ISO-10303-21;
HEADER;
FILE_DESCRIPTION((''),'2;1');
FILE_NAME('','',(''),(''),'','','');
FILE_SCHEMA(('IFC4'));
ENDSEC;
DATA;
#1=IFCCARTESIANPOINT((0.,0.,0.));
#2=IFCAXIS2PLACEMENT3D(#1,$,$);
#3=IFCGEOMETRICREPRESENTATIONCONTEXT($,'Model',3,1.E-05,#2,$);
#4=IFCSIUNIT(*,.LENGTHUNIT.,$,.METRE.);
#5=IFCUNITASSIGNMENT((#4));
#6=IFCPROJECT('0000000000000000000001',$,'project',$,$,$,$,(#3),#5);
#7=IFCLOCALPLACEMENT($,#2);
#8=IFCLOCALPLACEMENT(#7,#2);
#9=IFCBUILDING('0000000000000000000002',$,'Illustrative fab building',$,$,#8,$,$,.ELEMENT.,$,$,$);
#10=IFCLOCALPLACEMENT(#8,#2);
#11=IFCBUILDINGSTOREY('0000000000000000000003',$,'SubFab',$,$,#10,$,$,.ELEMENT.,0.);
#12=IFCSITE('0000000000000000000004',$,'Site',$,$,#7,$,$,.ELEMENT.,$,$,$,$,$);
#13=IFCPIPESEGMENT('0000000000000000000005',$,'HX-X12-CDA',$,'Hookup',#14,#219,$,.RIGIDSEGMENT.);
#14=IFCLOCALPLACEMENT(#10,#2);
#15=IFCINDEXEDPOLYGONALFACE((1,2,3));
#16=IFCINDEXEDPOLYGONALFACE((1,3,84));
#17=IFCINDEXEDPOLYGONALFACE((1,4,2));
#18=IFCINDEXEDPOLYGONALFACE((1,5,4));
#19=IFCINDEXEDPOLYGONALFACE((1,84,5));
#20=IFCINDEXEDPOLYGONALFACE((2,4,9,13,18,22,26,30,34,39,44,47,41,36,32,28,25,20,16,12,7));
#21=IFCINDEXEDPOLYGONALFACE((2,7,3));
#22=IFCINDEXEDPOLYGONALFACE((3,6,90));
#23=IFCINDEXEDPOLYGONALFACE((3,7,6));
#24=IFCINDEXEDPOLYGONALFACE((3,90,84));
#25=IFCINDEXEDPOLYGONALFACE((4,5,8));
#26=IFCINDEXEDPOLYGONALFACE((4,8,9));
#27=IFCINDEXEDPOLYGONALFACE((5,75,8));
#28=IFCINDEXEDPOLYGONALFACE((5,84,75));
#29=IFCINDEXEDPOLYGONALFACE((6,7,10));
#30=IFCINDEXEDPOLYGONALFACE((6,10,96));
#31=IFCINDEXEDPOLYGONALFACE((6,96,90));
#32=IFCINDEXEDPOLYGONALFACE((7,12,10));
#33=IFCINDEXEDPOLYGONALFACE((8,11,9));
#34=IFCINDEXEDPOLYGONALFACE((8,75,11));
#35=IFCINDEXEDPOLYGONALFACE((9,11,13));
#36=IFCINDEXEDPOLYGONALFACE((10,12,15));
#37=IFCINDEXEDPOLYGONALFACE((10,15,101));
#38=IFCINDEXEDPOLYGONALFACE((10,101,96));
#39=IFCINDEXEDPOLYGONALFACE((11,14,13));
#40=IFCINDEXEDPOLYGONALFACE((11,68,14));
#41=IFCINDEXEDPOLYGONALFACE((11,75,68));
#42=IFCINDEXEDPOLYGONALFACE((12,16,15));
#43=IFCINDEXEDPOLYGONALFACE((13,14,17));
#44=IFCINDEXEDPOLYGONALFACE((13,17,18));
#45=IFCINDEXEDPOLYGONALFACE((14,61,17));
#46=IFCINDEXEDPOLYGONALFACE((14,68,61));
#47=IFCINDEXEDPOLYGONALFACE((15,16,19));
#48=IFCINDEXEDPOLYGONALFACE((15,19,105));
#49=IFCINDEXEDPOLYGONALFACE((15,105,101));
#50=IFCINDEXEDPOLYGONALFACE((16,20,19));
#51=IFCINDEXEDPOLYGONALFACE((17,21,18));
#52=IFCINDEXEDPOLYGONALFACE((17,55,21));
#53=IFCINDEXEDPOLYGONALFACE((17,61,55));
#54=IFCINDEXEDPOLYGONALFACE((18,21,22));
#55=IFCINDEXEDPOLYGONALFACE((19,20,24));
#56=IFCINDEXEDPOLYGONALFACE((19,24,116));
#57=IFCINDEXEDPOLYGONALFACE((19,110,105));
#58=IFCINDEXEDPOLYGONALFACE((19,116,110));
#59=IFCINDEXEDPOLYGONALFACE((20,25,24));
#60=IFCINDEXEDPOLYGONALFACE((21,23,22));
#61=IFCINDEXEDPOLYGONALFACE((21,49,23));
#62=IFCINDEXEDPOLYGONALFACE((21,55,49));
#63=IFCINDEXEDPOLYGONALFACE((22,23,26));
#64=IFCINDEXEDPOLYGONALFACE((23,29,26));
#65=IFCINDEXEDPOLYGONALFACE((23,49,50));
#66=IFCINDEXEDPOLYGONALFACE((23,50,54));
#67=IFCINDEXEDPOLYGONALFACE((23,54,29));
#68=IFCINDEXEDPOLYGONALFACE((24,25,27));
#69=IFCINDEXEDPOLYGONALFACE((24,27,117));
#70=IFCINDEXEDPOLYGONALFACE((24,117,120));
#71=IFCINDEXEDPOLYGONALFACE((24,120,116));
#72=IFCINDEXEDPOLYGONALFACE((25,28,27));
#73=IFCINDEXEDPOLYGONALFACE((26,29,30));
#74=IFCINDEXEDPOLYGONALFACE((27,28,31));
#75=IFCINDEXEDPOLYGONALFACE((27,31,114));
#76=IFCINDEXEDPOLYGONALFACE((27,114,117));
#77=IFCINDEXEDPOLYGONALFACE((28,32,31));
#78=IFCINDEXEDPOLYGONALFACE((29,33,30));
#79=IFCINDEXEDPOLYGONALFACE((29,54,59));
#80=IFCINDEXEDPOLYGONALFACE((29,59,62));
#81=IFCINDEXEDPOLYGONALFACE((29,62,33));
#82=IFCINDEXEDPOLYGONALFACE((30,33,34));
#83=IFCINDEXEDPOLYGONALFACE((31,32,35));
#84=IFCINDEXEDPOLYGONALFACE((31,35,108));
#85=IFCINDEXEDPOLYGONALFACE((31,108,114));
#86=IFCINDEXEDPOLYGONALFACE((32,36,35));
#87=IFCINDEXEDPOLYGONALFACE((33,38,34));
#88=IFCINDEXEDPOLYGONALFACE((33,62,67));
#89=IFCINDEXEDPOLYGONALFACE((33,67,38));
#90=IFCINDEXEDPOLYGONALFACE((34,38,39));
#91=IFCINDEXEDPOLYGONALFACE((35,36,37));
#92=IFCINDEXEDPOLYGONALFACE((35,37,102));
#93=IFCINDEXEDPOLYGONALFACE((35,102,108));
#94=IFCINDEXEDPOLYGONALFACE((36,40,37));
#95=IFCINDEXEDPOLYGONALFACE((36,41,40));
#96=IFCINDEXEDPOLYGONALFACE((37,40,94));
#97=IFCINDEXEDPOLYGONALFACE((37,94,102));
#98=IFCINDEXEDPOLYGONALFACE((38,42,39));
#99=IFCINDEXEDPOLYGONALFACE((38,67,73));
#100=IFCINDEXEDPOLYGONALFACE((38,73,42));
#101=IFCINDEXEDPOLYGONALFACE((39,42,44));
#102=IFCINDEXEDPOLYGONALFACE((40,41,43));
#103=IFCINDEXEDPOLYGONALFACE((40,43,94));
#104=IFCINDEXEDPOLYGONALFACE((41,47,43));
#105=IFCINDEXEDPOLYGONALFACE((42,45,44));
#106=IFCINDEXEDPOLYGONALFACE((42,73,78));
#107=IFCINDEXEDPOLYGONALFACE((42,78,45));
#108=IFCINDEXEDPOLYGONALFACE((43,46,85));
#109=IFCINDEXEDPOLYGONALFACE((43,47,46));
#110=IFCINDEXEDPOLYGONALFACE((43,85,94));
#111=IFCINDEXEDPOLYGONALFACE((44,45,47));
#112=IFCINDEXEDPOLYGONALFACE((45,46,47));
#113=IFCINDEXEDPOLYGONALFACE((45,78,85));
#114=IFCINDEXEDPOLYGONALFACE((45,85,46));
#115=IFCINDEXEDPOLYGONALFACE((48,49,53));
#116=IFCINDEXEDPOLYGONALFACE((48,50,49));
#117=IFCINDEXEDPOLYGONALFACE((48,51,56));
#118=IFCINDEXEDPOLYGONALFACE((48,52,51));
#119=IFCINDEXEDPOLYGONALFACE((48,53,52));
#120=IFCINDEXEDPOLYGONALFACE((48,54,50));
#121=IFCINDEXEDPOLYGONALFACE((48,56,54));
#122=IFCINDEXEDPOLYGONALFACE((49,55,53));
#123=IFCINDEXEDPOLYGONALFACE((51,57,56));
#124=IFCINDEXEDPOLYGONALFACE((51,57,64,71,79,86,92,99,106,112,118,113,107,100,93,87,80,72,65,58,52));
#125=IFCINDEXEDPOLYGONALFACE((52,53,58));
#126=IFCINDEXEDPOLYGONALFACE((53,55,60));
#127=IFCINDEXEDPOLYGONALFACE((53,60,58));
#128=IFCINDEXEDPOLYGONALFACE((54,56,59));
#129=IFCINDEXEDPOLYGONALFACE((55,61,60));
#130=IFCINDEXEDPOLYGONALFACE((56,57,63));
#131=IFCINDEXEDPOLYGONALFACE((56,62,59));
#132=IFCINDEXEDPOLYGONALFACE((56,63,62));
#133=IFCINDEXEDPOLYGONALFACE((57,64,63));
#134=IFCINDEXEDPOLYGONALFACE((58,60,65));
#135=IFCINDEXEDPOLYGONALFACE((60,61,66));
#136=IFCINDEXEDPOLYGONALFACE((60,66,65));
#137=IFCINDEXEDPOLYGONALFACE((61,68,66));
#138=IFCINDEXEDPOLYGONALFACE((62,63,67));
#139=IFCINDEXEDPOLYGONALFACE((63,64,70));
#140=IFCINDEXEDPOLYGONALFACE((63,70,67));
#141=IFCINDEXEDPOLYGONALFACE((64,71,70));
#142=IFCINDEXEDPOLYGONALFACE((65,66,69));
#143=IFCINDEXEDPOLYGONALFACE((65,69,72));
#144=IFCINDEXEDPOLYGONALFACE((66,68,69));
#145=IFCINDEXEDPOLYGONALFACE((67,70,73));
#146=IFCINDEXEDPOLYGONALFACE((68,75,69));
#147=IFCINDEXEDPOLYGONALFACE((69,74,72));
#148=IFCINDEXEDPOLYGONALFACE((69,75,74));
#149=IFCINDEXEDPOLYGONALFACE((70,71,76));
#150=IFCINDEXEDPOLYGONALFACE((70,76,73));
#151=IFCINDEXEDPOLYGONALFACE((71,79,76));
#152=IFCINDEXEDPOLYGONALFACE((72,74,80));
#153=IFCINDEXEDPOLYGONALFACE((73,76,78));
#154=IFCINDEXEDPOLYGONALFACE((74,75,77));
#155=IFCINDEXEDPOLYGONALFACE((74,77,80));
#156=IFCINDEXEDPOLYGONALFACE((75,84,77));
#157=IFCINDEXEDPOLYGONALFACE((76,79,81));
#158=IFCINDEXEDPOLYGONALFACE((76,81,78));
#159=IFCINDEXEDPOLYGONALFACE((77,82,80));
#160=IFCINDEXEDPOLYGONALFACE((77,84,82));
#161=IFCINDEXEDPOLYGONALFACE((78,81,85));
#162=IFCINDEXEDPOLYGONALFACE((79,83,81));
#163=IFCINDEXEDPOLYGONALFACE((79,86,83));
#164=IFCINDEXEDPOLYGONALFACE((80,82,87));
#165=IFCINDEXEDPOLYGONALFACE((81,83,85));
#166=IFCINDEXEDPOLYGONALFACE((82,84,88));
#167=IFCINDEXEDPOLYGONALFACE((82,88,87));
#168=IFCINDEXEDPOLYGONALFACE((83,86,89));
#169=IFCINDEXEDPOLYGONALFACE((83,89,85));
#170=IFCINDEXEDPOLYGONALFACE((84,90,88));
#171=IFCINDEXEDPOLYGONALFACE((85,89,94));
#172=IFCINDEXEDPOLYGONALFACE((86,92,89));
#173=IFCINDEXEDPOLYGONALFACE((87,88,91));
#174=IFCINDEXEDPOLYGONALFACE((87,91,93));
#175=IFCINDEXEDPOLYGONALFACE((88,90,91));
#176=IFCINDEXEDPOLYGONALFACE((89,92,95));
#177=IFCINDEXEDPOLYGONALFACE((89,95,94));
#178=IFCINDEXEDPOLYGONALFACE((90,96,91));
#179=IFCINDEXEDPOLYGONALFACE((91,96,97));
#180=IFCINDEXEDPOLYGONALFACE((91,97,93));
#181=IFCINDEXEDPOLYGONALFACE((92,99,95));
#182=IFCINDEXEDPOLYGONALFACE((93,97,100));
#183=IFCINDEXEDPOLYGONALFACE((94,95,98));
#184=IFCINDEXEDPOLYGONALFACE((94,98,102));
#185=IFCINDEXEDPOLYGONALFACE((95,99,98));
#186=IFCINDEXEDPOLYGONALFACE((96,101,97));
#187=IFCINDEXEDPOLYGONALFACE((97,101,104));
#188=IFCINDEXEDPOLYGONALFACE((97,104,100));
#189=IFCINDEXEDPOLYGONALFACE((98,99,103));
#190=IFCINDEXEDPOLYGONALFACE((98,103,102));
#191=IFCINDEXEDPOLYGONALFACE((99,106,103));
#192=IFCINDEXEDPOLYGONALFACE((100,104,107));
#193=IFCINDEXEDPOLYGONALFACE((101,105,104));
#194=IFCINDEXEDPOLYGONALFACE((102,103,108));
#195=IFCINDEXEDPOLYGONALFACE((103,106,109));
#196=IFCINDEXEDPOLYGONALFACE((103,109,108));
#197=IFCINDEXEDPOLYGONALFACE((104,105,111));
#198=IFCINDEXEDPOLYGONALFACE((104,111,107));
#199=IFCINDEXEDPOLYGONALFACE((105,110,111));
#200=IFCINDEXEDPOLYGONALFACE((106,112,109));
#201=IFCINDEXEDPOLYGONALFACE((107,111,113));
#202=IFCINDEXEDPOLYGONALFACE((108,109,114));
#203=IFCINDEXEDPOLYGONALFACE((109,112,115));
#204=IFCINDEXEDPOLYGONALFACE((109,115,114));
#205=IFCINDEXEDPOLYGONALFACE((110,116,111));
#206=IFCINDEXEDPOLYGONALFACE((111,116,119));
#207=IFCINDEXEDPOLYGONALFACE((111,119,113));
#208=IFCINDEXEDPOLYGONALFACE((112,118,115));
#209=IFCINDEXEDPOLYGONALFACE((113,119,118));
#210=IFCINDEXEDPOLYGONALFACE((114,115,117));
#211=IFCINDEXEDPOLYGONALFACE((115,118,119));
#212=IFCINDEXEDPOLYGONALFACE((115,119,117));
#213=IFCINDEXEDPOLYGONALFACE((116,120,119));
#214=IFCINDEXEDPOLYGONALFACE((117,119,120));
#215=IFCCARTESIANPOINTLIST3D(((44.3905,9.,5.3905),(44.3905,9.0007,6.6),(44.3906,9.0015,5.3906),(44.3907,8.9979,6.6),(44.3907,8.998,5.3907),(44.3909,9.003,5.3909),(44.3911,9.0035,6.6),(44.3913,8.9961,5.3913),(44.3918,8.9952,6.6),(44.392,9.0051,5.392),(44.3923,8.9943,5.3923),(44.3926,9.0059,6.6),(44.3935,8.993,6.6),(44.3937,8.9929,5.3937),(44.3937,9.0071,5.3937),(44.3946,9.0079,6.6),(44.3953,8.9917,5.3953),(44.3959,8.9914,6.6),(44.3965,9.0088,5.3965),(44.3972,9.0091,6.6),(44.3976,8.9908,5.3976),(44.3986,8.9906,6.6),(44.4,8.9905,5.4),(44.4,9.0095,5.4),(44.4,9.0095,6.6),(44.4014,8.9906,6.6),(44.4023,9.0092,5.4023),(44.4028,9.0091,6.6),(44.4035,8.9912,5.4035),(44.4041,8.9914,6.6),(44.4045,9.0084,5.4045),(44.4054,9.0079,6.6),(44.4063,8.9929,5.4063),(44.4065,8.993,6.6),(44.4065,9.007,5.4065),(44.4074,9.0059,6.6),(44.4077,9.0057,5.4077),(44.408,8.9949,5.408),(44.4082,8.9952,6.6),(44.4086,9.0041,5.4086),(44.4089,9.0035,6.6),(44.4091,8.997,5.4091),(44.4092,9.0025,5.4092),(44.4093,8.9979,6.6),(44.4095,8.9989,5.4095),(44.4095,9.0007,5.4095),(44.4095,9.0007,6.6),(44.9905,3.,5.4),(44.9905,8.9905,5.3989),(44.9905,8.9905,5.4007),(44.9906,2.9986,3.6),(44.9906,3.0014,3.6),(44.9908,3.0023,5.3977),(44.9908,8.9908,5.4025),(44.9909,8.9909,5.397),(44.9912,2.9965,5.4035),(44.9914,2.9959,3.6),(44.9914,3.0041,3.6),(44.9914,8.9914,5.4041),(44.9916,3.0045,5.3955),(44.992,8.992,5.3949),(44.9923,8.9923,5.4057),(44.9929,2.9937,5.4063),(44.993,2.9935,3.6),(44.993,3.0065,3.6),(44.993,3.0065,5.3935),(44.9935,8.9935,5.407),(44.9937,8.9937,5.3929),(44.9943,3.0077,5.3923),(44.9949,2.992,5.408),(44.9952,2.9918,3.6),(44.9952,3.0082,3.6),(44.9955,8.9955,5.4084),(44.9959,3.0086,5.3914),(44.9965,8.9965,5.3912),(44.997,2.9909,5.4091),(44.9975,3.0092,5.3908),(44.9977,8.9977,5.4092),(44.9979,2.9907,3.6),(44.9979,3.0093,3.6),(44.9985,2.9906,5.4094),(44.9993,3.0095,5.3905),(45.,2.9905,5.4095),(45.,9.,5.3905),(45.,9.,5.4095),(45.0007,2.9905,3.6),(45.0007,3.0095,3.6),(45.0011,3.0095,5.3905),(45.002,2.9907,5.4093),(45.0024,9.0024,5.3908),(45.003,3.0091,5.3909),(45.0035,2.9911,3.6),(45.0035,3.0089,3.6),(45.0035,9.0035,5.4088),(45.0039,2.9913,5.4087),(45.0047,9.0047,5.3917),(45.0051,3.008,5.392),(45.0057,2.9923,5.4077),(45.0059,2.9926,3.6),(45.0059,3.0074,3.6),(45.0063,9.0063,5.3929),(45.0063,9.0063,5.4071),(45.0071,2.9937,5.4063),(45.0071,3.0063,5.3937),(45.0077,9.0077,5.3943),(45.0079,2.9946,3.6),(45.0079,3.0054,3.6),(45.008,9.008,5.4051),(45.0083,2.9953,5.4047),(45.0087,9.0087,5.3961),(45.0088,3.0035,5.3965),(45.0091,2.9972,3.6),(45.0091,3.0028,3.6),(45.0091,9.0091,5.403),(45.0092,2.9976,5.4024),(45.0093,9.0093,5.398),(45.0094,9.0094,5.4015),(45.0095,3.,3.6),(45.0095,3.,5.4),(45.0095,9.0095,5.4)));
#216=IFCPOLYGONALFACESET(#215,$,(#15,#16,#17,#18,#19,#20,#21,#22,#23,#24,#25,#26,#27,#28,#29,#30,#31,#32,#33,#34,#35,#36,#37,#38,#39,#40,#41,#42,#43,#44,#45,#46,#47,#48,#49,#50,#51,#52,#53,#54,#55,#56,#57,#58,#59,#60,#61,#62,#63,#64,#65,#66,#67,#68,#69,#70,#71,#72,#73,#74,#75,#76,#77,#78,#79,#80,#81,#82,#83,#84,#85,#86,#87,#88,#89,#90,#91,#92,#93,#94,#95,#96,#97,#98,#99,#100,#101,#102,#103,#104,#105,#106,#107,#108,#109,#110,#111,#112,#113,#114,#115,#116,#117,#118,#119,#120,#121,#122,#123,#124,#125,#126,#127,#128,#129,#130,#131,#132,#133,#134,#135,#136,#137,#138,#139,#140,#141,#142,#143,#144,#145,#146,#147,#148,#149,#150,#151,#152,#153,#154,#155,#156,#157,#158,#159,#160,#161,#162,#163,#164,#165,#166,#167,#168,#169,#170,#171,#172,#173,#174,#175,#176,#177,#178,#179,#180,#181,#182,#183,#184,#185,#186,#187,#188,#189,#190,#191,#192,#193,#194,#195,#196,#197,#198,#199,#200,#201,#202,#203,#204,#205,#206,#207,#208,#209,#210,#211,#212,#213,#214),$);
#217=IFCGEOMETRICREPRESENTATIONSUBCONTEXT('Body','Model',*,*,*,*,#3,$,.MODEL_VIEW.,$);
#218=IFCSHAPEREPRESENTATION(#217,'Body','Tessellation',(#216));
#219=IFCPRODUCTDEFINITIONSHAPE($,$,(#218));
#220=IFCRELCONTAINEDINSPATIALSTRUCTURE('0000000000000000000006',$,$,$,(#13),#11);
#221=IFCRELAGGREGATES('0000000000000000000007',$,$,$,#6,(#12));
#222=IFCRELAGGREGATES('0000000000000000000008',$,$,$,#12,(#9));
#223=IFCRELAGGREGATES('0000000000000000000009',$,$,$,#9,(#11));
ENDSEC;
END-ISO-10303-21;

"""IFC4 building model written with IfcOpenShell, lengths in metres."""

from ifc_helpers import new_model, entity, si_unit, origin, place, context, subcontext, project, spatial, element, save


model = new_model("IFC4")

# Units and contexts
model_context = context("Model", 3, precision=1e-05, world=origin())
body_context = subcontext(model_context, "Body", "Model", "MODEL_VIEW")
ifc_project = project(units=[si_unit("LENGTHUNIT", "METRE")], contexts=[model_context])

# Site, building, storey
site_placement = place(None, origin())
site = spatial("IfcSite", under=ifc_project, at=site_placement, Name="Site", CompositionType="ELEMENT")
building_placement = place(site_placement, origin())
building = spatial("IfcBuilding", under=site, at=building_placement, Name="Illustrative fab building", CompositionType="ELEMENT")
storey_placement = place(building_placement, origin())
storey = spatial("IfcBuildingStorey", under=building, at=storey_placement, Name="SubFab", CompositionType="ELEMENT", Elevation=0.0)

# Pipe segment
pipe_segment_1_placement = place(storey_placement, origin())
element("IfcPipeSegment", 1, at=pipe_segment_1_placement, inside=storey, Name="HX-X12-CDA", ObjectType="Hookup", PredefinedType="RIGIDSEGMENT", context=body_context, shape_type="AdvancedSweptSolid", body=[
    entity("IfcSweptDiskSolid", entity("IfcPolyline", [entity("IfcCartesianPoint", [45.0, 3.0, 3.6]), entity("IfcCartesianPoint", [45.0, 3.0, 5.4]), entity("IfcCartesianPoint", [45.0, 9.0, 5.4]), entity("IfcCartesianPoint", [44.4, 9.0, 5.4]), entity("IfcCartesianPoint", [44.4, 9.0, 6.6])]), 0.0095),
])

save(model, "model.ifc")
